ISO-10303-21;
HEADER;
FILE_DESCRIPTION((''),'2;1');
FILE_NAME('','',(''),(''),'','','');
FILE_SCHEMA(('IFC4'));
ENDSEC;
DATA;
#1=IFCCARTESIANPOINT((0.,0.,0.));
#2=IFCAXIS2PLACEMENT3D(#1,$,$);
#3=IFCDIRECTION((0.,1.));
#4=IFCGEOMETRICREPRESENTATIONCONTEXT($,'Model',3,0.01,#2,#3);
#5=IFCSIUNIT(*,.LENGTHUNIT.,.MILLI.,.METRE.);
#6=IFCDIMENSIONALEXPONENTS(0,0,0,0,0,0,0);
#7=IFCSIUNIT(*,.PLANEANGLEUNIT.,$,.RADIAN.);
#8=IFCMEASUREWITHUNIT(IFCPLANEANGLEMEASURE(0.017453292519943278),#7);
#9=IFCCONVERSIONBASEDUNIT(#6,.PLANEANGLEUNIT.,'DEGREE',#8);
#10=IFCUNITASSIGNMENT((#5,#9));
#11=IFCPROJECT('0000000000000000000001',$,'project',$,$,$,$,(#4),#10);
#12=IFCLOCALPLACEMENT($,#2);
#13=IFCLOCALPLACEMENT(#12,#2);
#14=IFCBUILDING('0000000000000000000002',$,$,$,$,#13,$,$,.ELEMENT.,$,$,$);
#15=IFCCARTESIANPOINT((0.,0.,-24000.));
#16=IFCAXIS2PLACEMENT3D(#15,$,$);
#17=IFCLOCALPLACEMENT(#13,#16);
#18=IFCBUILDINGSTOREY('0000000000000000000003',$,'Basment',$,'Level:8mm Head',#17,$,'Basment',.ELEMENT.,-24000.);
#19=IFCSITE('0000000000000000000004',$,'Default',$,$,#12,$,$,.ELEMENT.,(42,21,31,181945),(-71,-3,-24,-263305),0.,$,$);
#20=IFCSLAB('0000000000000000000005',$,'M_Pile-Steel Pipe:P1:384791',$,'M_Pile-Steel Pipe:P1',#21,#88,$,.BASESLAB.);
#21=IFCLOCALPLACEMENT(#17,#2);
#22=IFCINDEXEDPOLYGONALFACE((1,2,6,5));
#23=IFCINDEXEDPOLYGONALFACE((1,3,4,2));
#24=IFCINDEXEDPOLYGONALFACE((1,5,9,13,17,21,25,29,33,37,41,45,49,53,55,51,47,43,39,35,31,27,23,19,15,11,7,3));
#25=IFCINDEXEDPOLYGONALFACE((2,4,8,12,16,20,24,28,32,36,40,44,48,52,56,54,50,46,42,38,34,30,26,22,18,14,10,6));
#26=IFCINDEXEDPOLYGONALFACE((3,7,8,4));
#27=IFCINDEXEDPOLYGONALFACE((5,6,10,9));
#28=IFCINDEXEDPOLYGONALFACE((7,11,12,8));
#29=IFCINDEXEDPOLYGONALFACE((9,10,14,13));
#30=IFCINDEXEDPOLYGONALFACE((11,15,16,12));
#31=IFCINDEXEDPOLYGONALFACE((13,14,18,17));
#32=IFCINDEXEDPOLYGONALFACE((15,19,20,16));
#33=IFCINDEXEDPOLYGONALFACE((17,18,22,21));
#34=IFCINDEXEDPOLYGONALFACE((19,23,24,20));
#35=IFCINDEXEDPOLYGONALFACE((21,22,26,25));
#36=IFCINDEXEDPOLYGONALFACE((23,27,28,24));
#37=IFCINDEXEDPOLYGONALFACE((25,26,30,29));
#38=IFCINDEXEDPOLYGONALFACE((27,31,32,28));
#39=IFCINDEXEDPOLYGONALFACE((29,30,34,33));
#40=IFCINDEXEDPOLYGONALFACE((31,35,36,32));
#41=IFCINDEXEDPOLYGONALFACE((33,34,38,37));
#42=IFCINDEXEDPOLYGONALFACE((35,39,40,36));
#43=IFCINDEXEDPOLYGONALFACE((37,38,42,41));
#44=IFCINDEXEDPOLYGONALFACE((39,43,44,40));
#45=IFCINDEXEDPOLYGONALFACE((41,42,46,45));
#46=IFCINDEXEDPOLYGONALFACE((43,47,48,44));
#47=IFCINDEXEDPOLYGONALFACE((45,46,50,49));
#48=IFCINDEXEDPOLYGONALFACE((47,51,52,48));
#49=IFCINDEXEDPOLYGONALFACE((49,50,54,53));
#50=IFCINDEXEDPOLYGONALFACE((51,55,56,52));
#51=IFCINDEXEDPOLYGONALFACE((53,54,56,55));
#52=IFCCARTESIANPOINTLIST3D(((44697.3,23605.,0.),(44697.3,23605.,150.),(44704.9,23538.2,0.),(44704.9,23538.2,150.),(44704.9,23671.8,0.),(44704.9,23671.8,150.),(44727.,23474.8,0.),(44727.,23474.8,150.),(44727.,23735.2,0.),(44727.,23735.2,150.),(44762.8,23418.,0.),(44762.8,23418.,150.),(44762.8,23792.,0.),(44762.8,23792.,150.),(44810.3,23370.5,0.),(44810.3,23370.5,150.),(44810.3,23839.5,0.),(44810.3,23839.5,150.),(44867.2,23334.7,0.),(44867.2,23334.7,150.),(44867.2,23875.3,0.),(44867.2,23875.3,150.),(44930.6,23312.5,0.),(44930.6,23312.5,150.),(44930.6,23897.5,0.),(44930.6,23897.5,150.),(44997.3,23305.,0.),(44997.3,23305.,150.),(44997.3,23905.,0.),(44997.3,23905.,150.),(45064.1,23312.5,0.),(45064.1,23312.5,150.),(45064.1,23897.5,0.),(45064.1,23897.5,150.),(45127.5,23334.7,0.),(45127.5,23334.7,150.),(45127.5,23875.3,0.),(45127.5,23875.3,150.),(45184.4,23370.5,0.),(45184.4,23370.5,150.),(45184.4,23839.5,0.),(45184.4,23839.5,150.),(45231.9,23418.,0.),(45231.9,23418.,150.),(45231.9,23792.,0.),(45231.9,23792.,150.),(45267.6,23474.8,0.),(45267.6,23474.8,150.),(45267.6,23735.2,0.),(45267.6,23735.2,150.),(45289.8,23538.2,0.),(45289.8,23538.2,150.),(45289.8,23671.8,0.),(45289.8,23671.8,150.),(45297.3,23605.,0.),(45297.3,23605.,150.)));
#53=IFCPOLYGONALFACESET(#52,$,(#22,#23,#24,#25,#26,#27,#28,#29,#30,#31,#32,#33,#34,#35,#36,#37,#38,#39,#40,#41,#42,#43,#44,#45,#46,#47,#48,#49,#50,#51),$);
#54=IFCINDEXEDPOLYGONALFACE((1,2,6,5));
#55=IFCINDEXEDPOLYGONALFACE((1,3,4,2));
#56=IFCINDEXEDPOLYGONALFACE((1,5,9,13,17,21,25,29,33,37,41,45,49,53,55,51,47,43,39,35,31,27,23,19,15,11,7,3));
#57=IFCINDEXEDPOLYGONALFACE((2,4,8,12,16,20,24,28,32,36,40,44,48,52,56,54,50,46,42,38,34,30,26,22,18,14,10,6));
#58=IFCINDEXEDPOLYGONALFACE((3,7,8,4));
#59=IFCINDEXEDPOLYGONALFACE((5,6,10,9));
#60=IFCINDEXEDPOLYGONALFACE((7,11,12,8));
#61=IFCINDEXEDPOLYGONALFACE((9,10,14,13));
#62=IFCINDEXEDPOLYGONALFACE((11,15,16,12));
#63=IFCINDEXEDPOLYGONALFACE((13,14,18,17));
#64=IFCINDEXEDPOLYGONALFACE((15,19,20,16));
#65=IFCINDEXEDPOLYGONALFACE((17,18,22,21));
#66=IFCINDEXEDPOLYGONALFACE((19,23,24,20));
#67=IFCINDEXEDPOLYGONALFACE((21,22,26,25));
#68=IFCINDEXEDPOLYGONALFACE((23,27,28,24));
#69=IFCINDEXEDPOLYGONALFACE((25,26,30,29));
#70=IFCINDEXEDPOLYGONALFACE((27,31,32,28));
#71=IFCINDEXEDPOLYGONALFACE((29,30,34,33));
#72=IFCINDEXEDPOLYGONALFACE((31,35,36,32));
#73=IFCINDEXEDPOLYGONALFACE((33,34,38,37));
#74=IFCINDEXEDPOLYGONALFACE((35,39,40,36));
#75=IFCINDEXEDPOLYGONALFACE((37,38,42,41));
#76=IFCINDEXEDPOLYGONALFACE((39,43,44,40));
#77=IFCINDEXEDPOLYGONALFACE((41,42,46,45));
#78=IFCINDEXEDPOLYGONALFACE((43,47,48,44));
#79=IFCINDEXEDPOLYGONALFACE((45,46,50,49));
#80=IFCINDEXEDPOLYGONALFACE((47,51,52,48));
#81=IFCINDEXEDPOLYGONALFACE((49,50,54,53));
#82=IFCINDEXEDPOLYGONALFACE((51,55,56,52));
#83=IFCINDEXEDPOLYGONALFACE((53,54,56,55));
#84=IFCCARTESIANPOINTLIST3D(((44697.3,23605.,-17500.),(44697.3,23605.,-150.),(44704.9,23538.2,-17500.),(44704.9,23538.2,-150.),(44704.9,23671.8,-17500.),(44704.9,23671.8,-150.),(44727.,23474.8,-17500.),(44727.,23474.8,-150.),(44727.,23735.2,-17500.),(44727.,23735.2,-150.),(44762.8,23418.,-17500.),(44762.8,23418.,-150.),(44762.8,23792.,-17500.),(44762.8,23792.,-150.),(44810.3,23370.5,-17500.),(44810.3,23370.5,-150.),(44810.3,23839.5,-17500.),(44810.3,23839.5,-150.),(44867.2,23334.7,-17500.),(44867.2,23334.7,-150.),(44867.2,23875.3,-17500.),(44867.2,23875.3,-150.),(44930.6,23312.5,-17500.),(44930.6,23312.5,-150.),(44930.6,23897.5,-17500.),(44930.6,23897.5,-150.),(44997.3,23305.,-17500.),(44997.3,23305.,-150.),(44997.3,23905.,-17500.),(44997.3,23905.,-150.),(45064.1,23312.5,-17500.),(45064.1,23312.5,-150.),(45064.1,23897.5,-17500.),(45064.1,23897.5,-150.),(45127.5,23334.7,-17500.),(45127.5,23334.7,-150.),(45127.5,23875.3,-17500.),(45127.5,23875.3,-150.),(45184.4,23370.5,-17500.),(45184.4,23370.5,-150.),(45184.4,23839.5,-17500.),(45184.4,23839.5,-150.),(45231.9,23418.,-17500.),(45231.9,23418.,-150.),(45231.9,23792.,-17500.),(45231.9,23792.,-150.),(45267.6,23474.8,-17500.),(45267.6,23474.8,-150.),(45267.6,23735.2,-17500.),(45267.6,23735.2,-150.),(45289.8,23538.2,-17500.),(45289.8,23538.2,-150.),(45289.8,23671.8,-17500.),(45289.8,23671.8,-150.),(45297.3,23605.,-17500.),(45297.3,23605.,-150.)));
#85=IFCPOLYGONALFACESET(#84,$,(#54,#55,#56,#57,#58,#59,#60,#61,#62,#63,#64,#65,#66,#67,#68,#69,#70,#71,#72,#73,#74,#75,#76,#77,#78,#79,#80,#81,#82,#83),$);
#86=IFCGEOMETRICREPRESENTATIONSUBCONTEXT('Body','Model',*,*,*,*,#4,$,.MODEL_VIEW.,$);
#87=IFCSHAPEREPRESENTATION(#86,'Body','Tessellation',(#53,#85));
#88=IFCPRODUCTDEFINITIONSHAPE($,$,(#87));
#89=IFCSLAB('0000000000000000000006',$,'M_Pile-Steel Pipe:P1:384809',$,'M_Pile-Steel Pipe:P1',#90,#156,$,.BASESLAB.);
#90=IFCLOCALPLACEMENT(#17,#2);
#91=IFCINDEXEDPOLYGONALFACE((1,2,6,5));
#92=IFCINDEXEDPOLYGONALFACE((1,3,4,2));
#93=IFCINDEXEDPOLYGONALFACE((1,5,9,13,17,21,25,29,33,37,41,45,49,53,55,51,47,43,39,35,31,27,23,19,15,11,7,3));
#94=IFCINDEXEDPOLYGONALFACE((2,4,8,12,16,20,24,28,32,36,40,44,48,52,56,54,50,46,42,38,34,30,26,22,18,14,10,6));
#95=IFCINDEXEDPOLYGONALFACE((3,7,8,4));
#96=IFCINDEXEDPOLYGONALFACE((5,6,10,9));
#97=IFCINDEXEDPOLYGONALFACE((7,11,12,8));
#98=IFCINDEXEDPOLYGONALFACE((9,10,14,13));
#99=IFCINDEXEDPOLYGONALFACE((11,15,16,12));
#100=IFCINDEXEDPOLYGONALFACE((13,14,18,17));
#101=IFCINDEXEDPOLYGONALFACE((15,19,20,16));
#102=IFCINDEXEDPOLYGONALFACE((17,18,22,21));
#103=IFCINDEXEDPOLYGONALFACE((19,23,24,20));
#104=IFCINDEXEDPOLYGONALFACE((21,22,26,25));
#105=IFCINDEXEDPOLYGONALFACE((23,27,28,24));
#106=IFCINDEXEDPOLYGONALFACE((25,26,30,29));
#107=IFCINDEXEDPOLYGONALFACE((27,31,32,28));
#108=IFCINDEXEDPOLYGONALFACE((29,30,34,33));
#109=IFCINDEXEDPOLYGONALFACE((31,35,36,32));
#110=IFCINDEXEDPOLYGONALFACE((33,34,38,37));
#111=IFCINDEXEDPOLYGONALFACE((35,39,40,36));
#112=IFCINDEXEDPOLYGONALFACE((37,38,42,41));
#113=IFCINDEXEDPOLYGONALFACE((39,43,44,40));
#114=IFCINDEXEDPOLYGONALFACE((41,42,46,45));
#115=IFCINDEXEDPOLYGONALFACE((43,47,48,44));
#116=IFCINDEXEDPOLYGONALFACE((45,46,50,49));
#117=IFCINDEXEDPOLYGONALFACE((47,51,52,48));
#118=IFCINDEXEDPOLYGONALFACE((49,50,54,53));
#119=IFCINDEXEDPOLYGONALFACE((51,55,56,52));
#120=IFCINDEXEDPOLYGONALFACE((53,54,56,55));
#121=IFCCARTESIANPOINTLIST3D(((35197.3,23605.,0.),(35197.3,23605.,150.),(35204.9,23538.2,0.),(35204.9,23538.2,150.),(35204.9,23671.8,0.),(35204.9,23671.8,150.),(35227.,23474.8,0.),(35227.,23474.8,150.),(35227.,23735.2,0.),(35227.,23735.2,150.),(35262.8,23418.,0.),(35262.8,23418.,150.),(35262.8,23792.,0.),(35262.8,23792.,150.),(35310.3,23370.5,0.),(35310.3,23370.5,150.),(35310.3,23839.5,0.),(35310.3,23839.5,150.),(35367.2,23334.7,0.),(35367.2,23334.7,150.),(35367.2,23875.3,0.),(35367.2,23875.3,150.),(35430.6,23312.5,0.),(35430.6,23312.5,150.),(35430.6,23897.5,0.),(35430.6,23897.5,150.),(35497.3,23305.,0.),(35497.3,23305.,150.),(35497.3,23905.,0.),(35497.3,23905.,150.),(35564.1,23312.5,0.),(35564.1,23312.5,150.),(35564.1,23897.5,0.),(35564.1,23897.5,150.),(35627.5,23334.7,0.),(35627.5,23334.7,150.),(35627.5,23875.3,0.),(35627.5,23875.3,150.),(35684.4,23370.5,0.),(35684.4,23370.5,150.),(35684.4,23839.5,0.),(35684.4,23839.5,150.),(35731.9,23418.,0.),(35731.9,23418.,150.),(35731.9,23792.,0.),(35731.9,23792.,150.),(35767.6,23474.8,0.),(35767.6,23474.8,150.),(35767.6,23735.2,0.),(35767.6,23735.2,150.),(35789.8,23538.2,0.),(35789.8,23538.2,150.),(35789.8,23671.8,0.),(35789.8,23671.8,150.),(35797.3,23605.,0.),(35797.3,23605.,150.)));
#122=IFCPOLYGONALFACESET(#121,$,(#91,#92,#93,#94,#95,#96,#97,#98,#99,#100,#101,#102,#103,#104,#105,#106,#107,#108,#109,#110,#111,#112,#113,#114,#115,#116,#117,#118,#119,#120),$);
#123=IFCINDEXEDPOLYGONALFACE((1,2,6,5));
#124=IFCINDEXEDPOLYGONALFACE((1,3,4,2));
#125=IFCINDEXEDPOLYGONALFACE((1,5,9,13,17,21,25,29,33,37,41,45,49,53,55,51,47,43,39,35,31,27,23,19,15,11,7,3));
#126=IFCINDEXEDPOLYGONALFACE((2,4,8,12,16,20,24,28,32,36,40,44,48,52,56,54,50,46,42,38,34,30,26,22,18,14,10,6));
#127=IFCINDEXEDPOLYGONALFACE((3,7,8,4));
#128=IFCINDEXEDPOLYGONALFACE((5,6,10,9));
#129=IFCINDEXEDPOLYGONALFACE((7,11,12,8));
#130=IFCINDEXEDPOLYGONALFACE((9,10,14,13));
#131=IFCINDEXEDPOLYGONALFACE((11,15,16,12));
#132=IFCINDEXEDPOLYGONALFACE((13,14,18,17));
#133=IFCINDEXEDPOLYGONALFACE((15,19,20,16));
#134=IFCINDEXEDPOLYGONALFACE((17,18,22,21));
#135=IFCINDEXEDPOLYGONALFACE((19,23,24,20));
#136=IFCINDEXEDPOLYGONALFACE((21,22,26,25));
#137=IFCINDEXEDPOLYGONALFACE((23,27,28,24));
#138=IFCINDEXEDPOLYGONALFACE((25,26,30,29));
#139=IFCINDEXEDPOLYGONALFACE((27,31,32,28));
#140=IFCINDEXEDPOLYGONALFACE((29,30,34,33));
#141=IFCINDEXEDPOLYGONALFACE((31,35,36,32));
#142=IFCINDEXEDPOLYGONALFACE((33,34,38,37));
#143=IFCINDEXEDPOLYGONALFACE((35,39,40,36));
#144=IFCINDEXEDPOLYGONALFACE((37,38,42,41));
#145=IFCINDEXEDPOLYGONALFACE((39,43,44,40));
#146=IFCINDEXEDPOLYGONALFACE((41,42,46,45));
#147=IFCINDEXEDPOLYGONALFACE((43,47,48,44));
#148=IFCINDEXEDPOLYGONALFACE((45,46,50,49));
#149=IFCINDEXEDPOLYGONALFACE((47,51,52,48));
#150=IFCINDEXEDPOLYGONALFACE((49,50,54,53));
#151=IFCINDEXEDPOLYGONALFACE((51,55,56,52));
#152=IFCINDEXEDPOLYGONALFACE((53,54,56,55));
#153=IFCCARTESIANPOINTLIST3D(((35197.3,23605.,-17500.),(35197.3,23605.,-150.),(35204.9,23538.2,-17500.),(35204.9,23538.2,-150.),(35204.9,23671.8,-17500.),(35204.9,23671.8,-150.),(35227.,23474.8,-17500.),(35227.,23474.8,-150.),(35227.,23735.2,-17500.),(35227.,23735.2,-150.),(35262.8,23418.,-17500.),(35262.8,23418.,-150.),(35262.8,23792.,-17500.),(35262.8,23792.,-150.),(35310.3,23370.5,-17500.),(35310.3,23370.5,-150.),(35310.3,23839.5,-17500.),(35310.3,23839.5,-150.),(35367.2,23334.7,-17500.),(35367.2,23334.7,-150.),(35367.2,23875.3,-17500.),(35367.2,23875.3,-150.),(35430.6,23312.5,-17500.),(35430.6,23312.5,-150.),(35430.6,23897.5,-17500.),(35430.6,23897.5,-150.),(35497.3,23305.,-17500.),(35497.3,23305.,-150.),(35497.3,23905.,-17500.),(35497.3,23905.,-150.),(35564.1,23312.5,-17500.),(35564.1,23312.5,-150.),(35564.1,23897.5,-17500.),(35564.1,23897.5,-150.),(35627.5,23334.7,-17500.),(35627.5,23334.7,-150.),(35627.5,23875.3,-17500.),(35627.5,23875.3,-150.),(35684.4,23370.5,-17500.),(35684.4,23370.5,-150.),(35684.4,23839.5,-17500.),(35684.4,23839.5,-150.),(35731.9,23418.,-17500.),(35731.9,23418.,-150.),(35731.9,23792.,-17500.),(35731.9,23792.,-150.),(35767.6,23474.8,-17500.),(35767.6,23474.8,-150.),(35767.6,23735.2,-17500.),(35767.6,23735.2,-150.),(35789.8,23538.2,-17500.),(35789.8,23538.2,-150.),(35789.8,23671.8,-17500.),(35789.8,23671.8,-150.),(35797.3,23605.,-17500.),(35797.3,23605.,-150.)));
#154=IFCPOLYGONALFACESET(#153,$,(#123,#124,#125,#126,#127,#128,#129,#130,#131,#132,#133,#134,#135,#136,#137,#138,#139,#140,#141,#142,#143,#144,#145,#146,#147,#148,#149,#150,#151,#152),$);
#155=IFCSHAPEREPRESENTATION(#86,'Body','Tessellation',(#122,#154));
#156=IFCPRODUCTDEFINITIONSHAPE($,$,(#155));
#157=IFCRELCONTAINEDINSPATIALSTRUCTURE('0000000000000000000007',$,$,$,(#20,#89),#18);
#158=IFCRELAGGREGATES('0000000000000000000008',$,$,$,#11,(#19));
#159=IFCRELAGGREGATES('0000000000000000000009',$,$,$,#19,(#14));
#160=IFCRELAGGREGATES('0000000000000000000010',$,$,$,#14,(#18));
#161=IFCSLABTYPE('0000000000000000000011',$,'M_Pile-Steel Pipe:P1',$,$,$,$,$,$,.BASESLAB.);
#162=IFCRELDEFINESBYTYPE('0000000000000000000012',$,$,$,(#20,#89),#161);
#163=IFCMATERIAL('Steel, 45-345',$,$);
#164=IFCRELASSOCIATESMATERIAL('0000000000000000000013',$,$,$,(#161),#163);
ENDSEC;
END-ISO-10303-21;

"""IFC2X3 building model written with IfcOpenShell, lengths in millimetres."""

from ifc_helpers import new_model, entity, si_unit, converted_unit, direction, frame, origin, origin_2d_with_axis, place, context, subcontext, project, spatial, circle, extrude, material, type_object, element, save


model = new_model("IFC2X3")

# Units and contexts
model_context = context("Model", 3, precision=0.01, world=origin(), true_north=direction((0.0, 1.0)))
body_context = subcontext(model_context, "Body", "Model", "MODEL_VIEW")
ifc_project = project(units=[si_unit("LENGTHUNIT", "METRE", prefix="MILLI"), converted_unit("PLANEANGLEUNIT", "DEGREE", entity("IfcPlaneAngleMeasure", 0.017453292519943278), si_unit("PLANEANGLEUNIT", "RADIAN"), dimensions=[0, 0, 0, 0, 0, 0, 0])], contexts=[model_context])

# Site, building, storey
site_placement = place(None, origin())
site = spatial("IfcSite", under=ifc_project, at=site_placement, Name="Default", CompositionType="ELEMENT", RefLatitude=(42, 21, 31, 181945), RefLongitude=(-71, -3, -24, -263305), RefElevation=0.0)
building_placement = place(site_placement, origin())
building = spatial("IfcBuilding", under=site, at=building_placement, CompositionType="ELEMENT")
storey_placement = place(building_placement, frame((0.0, 0.0, -24000.0)))
storey = spatial("IfcBuildingStorey", under=building, at=storey_placement, Name="Basment", ObjectType="Level:8mm Head", LongName="Basment", CompositionType="ELEMENT", Elevation=-24000.0)

# Slabs
ifc_material_1 = material(Name="Steel, 45-345")
slab_type_1 = type_object("IfcSlabType", Name="M_Pile-Steel Pipe:P1", PredefinedType="BASESLAB", material=ifc_material_1)
slab_1_placement = place(storey_placement, origin())
element("IfcSlab", 1, at=slab_1_placement, inside=storey, type_object=slab_type_1, Name="M_Pile-Steel Pipe:P1:384791", ObjectType="M_Pile-Steel Pipe:P1", PredefinedType="BASESLAB", context=body_context, shape_type="SweptSolid", body=[
    extrude(circle(Radius=300.0, at=origin_2d_with_axis()), frame((44997.3, 23605.0, 0.0), z_axis=(0.0, 0.0, 1.0), x_axis=(0.0, 1.0, 0.0)), (0.0, 0.0, 1.0), 150.0),
    extrude(circle(Radius=300.0, at=origin_2d_with_axis()), frame((44997.3, 23605.0, -17500.0), z_axis=(0.0, 0.0, 1.0), x_axis=(0.0, 1.0, 0.0)), (0.0, 0.0, 1.0), 17350.0),
])
slab_2_placement = place(storey_placement, origin())
element("IfcSlab", 2, at=slab_2_placement, inside=storey, type_object=slab_type_1, Name="M_Pile-Steel Pipe:P1:384809", ObjectType="M_Pile-Steel Pipe:P1", PredefinedType="BASESLAB", context=body_context, shape_type="SweptSolid", body=[
    extrude(circle(Radius=300.0, at=origin_2d_with_axis()), frame((35497.3, 23605.0, 0.0), z_axis=(0.0, 0.0, 1.0), x_axis=(0.0, 1.0, 0.0)), (0.0, 0.0, 1.0), 150.0),
    extrude(circle(Radius=300.0, at=origin_2d_with_axis()), frame((35497.3, 23605.0, -17500.0), z_axis=(0.0, 0.0, 1.0), x_axis=(0.0, 1.0, 0.0)), (0.0, 0.0, 1.0), 17350.0),
])

save(model, "model.ifc")
